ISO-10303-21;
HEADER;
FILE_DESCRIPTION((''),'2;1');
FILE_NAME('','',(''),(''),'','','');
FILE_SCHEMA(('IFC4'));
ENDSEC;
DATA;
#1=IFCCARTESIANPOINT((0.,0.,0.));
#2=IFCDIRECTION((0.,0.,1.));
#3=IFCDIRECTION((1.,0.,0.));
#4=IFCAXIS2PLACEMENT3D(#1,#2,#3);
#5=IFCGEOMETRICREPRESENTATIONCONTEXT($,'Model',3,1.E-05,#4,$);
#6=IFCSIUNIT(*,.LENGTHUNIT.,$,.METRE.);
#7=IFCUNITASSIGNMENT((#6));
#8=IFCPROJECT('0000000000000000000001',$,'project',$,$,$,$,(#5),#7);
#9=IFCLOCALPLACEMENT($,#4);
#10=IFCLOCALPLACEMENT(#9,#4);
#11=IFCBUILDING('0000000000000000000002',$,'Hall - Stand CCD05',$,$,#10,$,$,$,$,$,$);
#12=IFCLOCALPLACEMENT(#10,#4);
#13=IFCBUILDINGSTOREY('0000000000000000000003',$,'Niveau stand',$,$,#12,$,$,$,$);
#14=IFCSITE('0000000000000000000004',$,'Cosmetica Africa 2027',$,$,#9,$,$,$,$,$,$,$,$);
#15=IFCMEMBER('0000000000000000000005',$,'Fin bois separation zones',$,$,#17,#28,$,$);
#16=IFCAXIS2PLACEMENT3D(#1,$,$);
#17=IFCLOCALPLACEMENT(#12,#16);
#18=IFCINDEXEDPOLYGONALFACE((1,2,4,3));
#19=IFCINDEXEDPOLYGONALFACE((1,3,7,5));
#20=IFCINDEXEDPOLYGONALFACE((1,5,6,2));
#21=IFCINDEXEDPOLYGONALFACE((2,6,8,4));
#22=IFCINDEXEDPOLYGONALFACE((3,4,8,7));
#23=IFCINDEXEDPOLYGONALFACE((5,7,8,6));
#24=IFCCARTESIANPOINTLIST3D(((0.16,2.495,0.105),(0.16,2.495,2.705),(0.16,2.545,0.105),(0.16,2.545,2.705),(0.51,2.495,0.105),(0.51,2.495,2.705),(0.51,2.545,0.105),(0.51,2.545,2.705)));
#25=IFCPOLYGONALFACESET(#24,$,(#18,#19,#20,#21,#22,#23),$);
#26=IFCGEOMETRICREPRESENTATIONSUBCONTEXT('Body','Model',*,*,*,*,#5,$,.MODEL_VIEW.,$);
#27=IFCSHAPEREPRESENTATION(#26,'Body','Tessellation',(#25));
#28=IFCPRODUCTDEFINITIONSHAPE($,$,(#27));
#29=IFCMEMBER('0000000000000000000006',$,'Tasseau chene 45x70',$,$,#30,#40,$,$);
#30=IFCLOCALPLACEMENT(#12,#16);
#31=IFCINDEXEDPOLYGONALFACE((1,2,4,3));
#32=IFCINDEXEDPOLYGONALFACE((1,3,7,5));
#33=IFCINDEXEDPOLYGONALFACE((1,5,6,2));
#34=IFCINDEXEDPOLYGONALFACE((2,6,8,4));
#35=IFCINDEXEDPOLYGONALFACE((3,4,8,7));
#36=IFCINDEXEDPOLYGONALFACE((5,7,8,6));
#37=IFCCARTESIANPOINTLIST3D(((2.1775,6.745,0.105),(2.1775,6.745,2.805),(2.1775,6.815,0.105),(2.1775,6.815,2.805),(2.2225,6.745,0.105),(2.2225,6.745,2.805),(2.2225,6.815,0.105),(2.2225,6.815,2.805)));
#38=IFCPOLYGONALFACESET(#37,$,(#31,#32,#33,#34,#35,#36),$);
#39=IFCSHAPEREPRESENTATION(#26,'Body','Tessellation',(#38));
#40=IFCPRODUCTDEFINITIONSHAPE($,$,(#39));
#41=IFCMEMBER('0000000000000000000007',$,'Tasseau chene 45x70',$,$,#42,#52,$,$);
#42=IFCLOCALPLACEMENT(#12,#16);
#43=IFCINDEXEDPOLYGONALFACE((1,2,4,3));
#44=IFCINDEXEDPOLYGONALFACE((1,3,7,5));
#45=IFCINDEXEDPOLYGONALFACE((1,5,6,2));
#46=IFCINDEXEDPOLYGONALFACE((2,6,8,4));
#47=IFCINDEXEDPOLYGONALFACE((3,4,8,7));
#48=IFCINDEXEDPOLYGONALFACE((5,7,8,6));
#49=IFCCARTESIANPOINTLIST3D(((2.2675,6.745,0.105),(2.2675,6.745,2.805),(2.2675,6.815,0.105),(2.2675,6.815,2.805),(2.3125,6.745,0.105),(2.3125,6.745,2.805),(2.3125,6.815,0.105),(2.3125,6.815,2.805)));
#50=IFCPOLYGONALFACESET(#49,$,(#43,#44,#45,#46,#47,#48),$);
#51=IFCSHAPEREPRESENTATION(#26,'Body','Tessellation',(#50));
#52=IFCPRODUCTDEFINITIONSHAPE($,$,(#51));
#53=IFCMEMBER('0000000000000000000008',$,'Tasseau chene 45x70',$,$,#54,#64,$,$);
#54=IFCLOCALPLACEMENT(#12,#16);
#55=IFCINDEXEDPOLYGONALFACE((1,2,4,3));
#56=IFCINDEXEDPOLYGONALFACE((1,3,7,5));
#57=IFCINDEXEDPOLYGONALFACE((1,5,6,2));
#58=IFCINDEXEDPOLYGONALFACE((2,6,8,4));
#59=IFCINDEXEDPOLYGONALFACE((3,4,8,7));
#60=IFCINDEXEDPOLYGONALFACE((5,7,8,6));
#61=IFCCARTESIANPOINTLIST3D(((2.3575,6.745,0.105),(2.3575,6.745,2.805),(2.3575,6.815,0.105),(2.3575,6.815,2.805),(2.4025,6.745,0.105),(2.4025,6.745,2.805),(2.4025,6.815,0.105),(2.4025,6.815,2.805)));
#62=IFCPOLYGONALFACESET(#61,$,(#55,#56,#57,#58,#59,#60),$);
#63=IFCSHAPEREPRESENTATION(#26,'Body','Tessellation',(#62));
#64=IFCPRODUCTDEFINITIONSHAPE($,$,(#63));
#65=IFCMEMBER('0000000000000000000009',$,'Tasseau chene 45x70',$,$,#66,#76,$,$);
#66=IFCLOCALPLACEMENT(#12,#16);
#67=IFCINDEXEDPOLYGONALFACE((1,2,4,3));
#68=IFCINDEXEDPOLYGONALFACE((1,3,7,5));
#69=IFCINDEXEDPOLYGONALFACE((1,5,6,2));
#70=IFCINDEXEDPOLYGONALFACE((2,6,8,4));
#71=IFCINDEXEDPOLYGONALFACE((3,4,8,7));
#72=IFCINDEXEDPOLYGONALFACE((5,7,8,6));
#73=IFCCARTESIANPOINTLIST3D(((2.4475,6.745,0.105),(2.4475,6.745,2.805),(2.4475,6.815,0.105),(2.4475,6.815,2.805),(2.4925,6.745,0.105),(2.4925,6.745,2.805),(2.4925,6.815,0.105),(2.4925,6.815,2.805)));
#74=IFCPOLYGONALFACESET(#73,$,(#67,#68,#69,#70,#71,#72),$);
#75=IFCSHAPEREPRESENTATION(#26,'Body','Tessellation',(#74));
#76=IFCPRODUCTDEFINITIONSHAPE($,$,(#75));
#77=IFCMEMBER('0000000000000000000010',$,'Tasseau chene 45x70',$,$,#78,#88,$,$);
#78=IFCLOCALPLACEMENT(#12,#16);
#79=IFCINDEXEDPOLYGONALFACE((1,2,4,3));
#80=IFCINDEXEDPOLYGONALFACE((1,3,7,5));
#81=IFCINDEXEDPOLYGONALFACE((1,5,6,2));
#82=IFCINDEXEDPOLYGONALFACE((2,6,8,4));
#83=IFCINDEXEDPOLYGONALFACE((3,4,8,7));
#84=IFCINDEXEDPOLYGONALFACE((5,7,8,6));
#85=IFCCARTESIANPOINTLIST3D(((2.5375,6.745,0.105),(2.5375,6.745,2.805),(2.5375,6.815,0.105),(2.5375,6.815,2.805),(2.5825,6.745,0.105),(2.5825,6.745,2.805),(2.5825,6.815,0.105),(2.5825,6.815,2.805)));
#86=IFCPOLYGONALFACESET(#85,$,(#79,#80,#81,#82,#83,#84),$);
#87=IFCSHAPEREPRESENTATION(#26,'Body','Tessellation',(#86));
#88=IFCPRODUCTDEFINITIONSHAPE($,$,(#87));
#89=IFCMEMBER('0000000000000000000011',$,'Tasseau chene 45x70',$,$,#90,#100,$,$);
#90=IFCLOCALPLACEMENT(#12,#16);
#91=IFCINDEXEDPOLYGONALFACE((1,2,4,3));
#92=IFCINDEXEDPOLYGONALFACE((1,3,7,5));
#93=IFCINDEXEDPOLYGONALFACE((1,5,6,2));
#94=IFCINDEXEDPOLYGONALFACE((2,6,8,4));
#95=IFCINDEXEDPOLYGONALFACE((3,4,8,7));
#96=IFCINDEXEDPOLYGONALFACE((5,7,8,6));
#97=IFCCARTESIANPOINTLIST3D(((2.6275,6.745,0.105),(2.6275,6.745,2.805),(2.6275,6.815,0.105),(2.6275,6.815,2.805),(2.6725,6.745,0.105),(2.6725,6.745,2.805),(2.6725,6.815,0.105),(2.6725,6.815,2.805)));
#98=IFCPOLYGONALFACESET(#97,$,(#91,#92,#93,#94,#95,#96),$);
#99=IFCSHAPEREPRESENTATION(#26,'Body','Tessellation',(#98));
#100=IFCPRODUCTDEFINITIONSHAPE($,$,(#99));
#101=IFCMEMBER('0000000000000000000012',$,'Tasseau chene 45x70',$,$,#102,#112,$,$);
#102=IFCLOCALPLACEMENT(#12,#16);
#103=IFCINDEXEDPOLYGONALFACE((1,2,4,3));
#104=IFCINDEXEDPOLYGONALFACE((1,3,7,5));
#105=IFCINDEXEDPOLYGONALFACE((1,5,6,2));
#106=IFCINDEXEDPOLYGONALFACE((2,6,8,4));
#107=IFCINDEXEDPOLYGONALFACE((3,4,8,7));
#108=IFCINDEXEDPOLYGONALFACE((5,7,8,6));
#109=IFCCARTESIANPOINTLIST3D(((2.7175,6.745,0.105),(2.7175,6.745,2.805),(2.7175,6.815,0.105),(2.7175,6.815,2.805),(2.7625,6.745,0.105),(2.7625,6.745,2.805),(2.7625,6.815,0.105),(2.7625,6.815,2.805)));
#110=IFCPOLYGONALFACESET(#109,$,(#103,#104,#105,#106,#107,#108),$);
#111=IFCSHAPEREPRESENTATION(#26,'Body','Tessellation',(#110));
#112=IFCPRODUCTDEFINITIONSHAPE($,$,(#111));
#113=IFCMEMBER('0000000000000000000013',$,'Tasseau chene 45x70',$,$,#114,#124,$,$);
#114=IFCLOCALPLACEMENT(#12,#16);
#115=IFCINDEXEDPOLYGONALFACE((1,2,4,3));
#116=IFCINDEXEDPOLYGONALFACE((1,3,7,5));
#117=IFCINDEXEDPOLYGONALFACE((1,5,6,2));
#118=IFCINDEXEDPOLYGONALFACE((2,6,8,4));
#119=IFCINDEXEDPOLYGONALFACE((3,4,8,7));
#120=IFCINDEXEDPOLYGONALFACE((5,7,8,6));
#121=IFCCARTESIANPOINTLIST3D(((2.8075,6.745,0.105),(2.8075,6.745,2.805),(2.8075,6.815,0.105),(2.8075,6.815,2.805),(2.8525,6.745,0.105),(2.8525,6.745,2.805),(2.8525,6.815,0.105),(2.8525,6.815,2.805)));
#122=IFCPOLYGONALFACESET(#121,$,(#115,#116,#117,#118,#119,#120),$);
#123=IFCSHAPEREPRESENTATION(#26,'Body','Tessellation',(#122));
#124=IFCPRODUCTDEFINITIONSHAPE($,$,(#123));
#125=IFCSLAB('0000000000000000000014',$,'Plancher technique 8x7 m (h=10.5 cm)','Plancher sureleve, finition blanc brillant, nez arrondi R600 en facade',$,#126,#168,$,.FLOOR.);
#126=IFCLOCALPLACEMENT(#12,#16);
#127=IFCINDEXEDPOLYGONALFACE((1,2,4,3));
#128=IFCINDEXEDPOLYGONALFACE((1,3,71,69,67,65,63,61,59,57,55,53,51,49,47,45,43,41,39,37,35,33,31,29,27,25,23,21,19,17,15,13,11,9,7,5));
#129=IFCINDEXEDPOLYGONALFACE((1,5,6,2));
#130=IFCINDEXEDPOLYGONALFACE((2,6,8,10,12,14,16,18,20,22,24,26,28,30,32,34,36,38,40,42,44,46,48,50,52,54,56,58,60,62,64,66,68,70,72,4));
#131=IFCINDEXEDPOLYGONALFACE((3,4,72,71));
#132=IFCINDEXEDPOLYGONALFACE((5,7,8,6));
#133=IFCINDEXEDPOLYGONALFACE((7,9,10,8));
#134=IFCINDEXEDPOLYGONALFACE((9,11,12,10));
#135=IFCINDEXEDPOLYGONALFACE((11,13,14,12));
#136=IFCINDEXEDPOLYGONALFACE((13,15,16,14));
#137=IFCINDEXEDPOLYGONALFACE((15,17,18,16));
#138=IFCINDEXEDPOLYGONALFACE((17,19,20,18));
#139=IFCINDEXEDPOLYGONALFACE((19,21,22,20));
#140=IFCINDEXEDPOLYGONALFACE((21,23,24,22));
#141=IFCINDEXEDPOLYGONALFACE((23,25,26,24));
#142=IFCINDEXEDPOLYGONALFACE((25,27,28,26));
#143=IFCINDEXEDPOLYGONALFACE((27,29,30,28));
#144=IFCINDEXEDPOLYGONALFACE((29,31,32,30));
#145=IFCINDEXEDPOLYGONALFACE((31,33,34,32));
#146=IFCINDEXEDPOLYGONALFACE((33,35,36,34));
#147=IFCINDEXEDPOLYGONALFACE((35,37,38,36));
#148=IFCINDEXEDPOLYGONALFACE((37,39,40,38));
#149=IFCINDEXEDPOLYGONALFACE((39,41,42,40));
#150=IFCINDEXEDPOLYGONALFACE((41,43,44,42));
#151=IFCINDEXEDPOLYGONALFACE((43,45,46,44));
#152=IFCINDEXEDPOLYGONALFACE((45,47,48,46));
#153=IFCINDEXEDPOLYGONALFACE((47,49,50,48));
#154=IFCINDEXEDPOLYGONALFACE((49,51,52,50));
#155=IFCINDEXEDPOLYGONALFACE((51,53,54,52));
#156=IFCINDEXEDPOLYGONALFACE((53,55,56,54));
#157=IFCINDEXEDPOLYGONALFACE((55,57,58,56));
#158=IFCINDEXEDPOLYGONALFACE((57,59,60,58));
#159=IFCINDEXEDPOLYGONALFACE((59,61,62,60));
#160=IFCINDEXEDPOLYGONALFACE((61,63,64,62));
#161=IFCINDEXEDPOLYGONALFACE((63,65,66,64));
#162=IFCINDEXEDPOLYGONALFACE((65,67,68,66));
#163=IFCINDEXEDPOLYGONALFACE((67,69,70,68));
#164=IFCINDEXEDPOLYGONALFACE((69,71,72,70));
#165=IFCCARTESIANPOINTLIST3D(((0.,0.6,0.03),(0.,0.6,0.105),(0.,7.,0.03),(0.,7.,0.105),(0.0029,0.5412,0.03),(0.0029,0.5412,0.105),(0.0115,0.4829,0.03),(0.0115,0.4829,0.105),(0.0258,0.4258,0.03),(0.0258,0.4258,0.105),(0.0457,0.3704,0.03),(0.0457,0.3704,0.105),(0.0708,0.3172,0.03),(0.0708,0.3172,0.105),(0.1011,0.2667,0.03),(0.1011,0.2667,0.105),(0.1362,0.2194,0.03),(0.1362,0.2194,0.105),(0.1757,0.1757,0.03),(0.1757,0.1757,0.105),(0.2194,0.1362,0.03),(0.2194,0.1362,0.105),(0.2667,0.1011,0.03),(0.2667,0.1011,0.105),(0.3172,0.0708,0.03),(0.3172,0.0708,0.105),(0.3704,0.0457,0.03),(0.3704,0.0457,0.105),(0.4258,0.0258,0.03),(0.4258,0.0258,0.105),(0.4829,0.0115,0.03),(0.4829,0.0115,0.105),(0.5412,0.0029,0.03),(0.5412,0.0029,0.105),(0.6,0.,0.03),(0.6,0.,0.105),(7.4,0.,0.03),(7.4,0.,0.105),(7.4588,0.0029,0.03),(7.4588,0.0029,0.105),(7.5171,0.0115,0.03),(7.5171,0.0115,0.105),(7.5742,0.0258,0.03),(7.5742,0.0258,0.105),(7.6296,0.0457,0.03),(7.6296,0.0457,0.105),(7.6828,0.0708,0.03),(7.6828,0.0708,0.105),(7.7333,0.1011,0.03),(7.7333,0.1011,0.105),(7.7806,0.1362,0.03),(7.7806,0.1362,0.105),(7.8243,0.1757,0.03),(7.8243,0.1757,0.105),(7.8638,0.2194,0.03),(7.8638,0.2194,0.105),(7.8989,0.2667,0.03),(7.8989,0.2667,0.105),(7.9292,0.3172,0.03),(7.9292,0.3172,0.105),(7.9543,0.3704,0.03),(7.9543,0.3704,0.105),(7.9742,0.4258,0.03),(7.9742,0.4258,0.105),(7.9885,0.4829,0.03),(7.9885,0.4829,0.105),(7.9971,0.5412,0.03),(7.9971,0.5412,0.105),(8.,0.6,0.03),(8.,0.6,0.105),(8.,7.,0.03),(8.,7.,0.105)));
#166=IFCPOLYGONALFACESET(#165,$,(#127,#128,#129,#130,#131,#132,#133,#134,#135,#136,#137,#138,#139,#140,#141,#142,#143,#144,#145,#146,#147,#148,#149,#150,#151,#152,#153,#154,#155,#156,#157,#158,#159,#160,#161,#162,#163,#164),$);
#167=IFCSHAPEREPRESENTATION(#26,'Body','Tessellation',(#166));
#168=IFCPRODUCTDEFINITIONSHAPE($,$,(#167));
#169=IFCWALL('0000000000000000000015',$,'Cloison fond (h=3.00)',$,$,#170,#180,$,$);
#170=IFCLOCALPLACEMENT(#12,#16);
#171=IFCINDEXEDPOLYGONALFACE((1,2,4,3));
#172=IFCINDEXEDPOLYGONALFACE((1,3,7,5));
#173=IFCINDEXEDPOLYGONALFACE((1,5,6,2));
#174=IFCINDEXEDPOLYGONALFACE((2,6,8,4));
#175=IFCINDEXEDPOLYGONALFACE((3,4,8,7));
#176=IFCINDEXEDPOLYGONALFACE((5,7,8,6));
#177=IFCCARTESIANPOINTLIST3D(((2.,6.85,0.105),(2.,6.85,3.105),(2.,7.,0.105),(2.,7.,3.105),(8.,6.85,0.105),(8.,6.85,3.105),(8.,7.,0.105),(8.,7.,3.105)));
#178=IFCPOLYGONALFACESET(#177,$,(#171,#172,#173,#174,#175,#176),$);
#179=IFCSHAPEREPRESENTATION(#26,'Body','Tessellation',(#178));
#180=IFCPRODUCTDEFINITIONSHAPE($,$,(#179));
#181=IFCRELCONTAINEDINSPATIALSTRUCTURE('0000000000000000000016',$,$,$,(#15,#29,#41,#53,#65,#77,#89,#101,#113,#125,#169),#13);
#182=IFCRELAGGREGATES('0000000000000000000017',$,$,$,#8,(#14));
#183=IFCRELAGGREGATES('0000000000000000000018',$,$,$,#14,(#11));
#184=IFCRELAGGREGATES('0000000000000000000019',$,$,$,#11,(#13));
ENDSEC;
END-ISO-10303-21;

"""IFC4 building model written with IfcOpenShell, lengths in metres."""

from ifc_helpers import new_model, si_unit, frame, origin_with_axes, place, context, subcontext, project, spatial, polyline, outline, extrude, element, save


model = new_model("IFC4")

# Units and contexts
model_context = context("Model", 3, precision=1e-05, world=origin_with_axes())
body_context = subcontext(model_context, "Body", "Model", "MODEL_VIEW")
ifc_project = project(units=[si_unit("LENGTHUNIT", "METRE")], contexts=[model_context])

# Site, building, storey
site_placement = place(None, origin_with_axes())
site = spatial("IfcSite", under=ifc_project, at=site_placement, Name="Cosmetica Africa 2027")
building_placement = place(site_placement, origin_with_axes())
building = spatial("IfcBuilding", under=site, at=building_placement, Name="Hall - Stand CCD05")
storey_placement = place(building_placement, origin_with_axes())
storey = spatial("IfcBuildingStorey", under=building, at=storey_placement, Name="Niveau stand")

# Members
member_1_placement = place(storey_placement, origin_with_axes())
element("IfcMember", 1, at=member_1_placement, inside=storey, Name="Fin bois separation zones", context=body_context, shape_type="SweptSolid", body=[
    extrude(outline(polyline([(0.16, 2.495), (0.51, 2.495), (0.51, 2.545), (0.16, 2.545), (0.16, 2.495)])), frame((0.0, 0.0, 0.105)), (0.0, 0.0, 1.0), 2.6),
])
member_2_placement = place(storey_placement, origin_with_axes())
element("IfcMember", 2, at=member_2_placement, inside=storey, Name="Tasseau chene 45x70", context=body_context, shape_type="SweptSolid", body=[
    extrude(outline(polyline([(2.1775, 6.745), (2.2225, 6.745), (2.2225, 6.815), (2.1775, 6.815), (2.1775, 6.745)])), frame((0.0, 0.0, 0.105)), (0.0, 0.0, 1.0), 2.7),
])
member_3_placement = place(storey_placement, origin_with_axes())
element("IfcMember", 3, at=member_3_placement, inside=storey, Name="Tasseau chene 45x70", context=body_context, shape_type="SweptSolid", body=[
    extrude(outline(polyline([(2.2675, 6.745), (2.3125, 6.745), (2.3125, 6.815), (2.2675, 6.815), (2.2675, 6.745)])), frame((0.0, 0.0, 0.105)), (0.0, 0.0, 1.0), 2.7),
])
member_4_placement = place(storey_placement, origin_with_axes())
element("IfcMember", 4, at=member_4_placement, inside=storey, Name="Tasseau chene 45x70", context=body_context, shape_type="SweptSolid", body=[
    extrude(outline(polyline([(2.3575, 6.745), (2.4025, 6.745), (2.4025, 6.815), (2.3575, 6.815), (2.3575, 6.745)])), frame((0.0, 0.0, 0.105)), (0.0, 0.0, 1.0), 2.7),
])
member_5_placement = place(storey_placement, origin_with_axes())
element("IfcMember", 5, at=member_5_placement, inside=storey, Name="Tasseau chene 45x70", context=body_context, shape_type="SweptSolid", body=[
    extrude(outline(polyline([(2.4475, 6.745), (2.4925, 6.745), (2.4925, 6.815), (2.4475, 6.815), (2.4475, 6.745)])), frame((0.0, 0.0, 0.105)), (0.0, 0.0, 1.0), 2.7),
])
member_6_placement = place(storey_placement, origin_with_axes())
element("IfcMember", 6, at=member_6_placement, inside=storey, Name="Tasseau chene 45x70", context=body_context, shape_type="SweptSolid", body=[
    extrude(outline(polyline([(2.5375, 6.745), (2.5825, 6.745), (2.5825, 6.815), (2.5375, 6.815), (2.5375, 6.745)])), frame((0.0, 0.0, 0.105)), (0.0, 0.0, 1.0), 2.7),
])
member_7_placement = place(storey_placement, origin_with_axes())
element("IfcMember", 7, at=member_7_placement, inside=storey, Name="Tasseau chene 45x70", context=body_context, shape_type="SweptSolid", body=[
    extrude(outline(polyline([(2.6275, 6.745), (2.6725, 6.745), (2.6725, 6.815), (2.6275, 6.815), (2.6275, 6.745)])), frame((0.0, 0.0, 0.105)), (0.0, 0.0, 1.0), 2.7),
])
member_8_placement = place(storey_placement, origin_with_axes())
element("IfcMember", 8, at=member_8_placement, inside=storey, Name="Tasseau chene 45x70", context=body_context, shape_type="SweptSolid", body=[
    extrude(outline(polyline([(2.7175, 6.745), (2.7625, 6.745), (2.7625, 6.815), (2.7175, 6.815), (2.7175, 6.745)])), frame((0.0, 0.0, 0.105)), (0.0, 0.0, 1.0), 2.7),
])
member_9_placement = place(storey_placement, origin_with_axes())
element("IfcMember", 9, at=member_9_placement, inside=storey, Name="Tasseau chene 45x70", context=body_context, shape_type="SweptSolid", body=[
    extrude(outline(polyline([(2.8075, 6.745), (2.8525, 6.745), (2.8525, 6.815), (2.8075, 6.815), (2.8075, 6.745)])), frame((0.0, 0.0, 0.105)), (0.0, 0.0, 1.0), 2.7),
])

# Slab
slab_placement = place(storey_placement, origin_with_axes())
element("IfcSlab", 10, at=slab_placement, inside=storey, Name="Plancher technique 8x7 m (h=10.5 cm)", Description="Plancher sureleve, finition blanc brillant, nez arrondi R600 en facade", PredefinedType="FLOOR", context=body_context, shape_type="SweptSolid", body=[
    extrude(outline(polyline([(0.0, 0.6), (0.0029, 0.5412), (0.0115, 0.4829), (0.0258, 0.4258), (0.0457, 0.3704), (0.0708, 0.3172), (0.1011, 0.2667), (0.1362, 0.2194), (0.1757, 0.1757), (0.2194, 0.1362), (0.2667, 0.1011), (0.3172, 0.0708), (0.3704, 0.0457), (0.4258, 0.0258), (0.4829, 0.0115), (0.5412, 0.0029), (0.6, 0.0), (7.4, 0.0), (7.4588, 0.0029), (7.5171, 0.0115), (7.5742, 0.0258), (7.6296, 0.0457), (7.6828, 0.0708), (7.7333, 0.1011), (7.7806, 0.1362), (7.8243, 0.1757), (7.8638, 0.2194), (7.8989, 0.2667), (7.9292, 0.3172), (7.9543, 0.3704), (7.9742, 0.4258), (7.9885, 0.4829), (7.9971, 0.5412), (8.0, 0.6), (8.0, 7.0), (0.0, 7.0), (0.0, 0.6)])), frame((0.0, 0.0, 0.03)), (0.0, 0.0, 1.0), 0.075),
])

# Wall
wall_1_placement = place(storey_placement, origin_with_axes())
element("IfcWall", 11, at=wall_1_placement, inside=storey, Name="Cloison fond (h=3.00)", context=body_context, shape_type="SweptSolid", body=[
    extrude(outline(polyline([(2.0, 6.85), (8.0, 6.85), (8.0, 7.0), (2.0, 7.0), (2.0, 6.85)])), frame((0.0, 0.0, 0.105)), (0.0, 0.0, 1.0), 3.0),
])

save(model, "model.ifc")
